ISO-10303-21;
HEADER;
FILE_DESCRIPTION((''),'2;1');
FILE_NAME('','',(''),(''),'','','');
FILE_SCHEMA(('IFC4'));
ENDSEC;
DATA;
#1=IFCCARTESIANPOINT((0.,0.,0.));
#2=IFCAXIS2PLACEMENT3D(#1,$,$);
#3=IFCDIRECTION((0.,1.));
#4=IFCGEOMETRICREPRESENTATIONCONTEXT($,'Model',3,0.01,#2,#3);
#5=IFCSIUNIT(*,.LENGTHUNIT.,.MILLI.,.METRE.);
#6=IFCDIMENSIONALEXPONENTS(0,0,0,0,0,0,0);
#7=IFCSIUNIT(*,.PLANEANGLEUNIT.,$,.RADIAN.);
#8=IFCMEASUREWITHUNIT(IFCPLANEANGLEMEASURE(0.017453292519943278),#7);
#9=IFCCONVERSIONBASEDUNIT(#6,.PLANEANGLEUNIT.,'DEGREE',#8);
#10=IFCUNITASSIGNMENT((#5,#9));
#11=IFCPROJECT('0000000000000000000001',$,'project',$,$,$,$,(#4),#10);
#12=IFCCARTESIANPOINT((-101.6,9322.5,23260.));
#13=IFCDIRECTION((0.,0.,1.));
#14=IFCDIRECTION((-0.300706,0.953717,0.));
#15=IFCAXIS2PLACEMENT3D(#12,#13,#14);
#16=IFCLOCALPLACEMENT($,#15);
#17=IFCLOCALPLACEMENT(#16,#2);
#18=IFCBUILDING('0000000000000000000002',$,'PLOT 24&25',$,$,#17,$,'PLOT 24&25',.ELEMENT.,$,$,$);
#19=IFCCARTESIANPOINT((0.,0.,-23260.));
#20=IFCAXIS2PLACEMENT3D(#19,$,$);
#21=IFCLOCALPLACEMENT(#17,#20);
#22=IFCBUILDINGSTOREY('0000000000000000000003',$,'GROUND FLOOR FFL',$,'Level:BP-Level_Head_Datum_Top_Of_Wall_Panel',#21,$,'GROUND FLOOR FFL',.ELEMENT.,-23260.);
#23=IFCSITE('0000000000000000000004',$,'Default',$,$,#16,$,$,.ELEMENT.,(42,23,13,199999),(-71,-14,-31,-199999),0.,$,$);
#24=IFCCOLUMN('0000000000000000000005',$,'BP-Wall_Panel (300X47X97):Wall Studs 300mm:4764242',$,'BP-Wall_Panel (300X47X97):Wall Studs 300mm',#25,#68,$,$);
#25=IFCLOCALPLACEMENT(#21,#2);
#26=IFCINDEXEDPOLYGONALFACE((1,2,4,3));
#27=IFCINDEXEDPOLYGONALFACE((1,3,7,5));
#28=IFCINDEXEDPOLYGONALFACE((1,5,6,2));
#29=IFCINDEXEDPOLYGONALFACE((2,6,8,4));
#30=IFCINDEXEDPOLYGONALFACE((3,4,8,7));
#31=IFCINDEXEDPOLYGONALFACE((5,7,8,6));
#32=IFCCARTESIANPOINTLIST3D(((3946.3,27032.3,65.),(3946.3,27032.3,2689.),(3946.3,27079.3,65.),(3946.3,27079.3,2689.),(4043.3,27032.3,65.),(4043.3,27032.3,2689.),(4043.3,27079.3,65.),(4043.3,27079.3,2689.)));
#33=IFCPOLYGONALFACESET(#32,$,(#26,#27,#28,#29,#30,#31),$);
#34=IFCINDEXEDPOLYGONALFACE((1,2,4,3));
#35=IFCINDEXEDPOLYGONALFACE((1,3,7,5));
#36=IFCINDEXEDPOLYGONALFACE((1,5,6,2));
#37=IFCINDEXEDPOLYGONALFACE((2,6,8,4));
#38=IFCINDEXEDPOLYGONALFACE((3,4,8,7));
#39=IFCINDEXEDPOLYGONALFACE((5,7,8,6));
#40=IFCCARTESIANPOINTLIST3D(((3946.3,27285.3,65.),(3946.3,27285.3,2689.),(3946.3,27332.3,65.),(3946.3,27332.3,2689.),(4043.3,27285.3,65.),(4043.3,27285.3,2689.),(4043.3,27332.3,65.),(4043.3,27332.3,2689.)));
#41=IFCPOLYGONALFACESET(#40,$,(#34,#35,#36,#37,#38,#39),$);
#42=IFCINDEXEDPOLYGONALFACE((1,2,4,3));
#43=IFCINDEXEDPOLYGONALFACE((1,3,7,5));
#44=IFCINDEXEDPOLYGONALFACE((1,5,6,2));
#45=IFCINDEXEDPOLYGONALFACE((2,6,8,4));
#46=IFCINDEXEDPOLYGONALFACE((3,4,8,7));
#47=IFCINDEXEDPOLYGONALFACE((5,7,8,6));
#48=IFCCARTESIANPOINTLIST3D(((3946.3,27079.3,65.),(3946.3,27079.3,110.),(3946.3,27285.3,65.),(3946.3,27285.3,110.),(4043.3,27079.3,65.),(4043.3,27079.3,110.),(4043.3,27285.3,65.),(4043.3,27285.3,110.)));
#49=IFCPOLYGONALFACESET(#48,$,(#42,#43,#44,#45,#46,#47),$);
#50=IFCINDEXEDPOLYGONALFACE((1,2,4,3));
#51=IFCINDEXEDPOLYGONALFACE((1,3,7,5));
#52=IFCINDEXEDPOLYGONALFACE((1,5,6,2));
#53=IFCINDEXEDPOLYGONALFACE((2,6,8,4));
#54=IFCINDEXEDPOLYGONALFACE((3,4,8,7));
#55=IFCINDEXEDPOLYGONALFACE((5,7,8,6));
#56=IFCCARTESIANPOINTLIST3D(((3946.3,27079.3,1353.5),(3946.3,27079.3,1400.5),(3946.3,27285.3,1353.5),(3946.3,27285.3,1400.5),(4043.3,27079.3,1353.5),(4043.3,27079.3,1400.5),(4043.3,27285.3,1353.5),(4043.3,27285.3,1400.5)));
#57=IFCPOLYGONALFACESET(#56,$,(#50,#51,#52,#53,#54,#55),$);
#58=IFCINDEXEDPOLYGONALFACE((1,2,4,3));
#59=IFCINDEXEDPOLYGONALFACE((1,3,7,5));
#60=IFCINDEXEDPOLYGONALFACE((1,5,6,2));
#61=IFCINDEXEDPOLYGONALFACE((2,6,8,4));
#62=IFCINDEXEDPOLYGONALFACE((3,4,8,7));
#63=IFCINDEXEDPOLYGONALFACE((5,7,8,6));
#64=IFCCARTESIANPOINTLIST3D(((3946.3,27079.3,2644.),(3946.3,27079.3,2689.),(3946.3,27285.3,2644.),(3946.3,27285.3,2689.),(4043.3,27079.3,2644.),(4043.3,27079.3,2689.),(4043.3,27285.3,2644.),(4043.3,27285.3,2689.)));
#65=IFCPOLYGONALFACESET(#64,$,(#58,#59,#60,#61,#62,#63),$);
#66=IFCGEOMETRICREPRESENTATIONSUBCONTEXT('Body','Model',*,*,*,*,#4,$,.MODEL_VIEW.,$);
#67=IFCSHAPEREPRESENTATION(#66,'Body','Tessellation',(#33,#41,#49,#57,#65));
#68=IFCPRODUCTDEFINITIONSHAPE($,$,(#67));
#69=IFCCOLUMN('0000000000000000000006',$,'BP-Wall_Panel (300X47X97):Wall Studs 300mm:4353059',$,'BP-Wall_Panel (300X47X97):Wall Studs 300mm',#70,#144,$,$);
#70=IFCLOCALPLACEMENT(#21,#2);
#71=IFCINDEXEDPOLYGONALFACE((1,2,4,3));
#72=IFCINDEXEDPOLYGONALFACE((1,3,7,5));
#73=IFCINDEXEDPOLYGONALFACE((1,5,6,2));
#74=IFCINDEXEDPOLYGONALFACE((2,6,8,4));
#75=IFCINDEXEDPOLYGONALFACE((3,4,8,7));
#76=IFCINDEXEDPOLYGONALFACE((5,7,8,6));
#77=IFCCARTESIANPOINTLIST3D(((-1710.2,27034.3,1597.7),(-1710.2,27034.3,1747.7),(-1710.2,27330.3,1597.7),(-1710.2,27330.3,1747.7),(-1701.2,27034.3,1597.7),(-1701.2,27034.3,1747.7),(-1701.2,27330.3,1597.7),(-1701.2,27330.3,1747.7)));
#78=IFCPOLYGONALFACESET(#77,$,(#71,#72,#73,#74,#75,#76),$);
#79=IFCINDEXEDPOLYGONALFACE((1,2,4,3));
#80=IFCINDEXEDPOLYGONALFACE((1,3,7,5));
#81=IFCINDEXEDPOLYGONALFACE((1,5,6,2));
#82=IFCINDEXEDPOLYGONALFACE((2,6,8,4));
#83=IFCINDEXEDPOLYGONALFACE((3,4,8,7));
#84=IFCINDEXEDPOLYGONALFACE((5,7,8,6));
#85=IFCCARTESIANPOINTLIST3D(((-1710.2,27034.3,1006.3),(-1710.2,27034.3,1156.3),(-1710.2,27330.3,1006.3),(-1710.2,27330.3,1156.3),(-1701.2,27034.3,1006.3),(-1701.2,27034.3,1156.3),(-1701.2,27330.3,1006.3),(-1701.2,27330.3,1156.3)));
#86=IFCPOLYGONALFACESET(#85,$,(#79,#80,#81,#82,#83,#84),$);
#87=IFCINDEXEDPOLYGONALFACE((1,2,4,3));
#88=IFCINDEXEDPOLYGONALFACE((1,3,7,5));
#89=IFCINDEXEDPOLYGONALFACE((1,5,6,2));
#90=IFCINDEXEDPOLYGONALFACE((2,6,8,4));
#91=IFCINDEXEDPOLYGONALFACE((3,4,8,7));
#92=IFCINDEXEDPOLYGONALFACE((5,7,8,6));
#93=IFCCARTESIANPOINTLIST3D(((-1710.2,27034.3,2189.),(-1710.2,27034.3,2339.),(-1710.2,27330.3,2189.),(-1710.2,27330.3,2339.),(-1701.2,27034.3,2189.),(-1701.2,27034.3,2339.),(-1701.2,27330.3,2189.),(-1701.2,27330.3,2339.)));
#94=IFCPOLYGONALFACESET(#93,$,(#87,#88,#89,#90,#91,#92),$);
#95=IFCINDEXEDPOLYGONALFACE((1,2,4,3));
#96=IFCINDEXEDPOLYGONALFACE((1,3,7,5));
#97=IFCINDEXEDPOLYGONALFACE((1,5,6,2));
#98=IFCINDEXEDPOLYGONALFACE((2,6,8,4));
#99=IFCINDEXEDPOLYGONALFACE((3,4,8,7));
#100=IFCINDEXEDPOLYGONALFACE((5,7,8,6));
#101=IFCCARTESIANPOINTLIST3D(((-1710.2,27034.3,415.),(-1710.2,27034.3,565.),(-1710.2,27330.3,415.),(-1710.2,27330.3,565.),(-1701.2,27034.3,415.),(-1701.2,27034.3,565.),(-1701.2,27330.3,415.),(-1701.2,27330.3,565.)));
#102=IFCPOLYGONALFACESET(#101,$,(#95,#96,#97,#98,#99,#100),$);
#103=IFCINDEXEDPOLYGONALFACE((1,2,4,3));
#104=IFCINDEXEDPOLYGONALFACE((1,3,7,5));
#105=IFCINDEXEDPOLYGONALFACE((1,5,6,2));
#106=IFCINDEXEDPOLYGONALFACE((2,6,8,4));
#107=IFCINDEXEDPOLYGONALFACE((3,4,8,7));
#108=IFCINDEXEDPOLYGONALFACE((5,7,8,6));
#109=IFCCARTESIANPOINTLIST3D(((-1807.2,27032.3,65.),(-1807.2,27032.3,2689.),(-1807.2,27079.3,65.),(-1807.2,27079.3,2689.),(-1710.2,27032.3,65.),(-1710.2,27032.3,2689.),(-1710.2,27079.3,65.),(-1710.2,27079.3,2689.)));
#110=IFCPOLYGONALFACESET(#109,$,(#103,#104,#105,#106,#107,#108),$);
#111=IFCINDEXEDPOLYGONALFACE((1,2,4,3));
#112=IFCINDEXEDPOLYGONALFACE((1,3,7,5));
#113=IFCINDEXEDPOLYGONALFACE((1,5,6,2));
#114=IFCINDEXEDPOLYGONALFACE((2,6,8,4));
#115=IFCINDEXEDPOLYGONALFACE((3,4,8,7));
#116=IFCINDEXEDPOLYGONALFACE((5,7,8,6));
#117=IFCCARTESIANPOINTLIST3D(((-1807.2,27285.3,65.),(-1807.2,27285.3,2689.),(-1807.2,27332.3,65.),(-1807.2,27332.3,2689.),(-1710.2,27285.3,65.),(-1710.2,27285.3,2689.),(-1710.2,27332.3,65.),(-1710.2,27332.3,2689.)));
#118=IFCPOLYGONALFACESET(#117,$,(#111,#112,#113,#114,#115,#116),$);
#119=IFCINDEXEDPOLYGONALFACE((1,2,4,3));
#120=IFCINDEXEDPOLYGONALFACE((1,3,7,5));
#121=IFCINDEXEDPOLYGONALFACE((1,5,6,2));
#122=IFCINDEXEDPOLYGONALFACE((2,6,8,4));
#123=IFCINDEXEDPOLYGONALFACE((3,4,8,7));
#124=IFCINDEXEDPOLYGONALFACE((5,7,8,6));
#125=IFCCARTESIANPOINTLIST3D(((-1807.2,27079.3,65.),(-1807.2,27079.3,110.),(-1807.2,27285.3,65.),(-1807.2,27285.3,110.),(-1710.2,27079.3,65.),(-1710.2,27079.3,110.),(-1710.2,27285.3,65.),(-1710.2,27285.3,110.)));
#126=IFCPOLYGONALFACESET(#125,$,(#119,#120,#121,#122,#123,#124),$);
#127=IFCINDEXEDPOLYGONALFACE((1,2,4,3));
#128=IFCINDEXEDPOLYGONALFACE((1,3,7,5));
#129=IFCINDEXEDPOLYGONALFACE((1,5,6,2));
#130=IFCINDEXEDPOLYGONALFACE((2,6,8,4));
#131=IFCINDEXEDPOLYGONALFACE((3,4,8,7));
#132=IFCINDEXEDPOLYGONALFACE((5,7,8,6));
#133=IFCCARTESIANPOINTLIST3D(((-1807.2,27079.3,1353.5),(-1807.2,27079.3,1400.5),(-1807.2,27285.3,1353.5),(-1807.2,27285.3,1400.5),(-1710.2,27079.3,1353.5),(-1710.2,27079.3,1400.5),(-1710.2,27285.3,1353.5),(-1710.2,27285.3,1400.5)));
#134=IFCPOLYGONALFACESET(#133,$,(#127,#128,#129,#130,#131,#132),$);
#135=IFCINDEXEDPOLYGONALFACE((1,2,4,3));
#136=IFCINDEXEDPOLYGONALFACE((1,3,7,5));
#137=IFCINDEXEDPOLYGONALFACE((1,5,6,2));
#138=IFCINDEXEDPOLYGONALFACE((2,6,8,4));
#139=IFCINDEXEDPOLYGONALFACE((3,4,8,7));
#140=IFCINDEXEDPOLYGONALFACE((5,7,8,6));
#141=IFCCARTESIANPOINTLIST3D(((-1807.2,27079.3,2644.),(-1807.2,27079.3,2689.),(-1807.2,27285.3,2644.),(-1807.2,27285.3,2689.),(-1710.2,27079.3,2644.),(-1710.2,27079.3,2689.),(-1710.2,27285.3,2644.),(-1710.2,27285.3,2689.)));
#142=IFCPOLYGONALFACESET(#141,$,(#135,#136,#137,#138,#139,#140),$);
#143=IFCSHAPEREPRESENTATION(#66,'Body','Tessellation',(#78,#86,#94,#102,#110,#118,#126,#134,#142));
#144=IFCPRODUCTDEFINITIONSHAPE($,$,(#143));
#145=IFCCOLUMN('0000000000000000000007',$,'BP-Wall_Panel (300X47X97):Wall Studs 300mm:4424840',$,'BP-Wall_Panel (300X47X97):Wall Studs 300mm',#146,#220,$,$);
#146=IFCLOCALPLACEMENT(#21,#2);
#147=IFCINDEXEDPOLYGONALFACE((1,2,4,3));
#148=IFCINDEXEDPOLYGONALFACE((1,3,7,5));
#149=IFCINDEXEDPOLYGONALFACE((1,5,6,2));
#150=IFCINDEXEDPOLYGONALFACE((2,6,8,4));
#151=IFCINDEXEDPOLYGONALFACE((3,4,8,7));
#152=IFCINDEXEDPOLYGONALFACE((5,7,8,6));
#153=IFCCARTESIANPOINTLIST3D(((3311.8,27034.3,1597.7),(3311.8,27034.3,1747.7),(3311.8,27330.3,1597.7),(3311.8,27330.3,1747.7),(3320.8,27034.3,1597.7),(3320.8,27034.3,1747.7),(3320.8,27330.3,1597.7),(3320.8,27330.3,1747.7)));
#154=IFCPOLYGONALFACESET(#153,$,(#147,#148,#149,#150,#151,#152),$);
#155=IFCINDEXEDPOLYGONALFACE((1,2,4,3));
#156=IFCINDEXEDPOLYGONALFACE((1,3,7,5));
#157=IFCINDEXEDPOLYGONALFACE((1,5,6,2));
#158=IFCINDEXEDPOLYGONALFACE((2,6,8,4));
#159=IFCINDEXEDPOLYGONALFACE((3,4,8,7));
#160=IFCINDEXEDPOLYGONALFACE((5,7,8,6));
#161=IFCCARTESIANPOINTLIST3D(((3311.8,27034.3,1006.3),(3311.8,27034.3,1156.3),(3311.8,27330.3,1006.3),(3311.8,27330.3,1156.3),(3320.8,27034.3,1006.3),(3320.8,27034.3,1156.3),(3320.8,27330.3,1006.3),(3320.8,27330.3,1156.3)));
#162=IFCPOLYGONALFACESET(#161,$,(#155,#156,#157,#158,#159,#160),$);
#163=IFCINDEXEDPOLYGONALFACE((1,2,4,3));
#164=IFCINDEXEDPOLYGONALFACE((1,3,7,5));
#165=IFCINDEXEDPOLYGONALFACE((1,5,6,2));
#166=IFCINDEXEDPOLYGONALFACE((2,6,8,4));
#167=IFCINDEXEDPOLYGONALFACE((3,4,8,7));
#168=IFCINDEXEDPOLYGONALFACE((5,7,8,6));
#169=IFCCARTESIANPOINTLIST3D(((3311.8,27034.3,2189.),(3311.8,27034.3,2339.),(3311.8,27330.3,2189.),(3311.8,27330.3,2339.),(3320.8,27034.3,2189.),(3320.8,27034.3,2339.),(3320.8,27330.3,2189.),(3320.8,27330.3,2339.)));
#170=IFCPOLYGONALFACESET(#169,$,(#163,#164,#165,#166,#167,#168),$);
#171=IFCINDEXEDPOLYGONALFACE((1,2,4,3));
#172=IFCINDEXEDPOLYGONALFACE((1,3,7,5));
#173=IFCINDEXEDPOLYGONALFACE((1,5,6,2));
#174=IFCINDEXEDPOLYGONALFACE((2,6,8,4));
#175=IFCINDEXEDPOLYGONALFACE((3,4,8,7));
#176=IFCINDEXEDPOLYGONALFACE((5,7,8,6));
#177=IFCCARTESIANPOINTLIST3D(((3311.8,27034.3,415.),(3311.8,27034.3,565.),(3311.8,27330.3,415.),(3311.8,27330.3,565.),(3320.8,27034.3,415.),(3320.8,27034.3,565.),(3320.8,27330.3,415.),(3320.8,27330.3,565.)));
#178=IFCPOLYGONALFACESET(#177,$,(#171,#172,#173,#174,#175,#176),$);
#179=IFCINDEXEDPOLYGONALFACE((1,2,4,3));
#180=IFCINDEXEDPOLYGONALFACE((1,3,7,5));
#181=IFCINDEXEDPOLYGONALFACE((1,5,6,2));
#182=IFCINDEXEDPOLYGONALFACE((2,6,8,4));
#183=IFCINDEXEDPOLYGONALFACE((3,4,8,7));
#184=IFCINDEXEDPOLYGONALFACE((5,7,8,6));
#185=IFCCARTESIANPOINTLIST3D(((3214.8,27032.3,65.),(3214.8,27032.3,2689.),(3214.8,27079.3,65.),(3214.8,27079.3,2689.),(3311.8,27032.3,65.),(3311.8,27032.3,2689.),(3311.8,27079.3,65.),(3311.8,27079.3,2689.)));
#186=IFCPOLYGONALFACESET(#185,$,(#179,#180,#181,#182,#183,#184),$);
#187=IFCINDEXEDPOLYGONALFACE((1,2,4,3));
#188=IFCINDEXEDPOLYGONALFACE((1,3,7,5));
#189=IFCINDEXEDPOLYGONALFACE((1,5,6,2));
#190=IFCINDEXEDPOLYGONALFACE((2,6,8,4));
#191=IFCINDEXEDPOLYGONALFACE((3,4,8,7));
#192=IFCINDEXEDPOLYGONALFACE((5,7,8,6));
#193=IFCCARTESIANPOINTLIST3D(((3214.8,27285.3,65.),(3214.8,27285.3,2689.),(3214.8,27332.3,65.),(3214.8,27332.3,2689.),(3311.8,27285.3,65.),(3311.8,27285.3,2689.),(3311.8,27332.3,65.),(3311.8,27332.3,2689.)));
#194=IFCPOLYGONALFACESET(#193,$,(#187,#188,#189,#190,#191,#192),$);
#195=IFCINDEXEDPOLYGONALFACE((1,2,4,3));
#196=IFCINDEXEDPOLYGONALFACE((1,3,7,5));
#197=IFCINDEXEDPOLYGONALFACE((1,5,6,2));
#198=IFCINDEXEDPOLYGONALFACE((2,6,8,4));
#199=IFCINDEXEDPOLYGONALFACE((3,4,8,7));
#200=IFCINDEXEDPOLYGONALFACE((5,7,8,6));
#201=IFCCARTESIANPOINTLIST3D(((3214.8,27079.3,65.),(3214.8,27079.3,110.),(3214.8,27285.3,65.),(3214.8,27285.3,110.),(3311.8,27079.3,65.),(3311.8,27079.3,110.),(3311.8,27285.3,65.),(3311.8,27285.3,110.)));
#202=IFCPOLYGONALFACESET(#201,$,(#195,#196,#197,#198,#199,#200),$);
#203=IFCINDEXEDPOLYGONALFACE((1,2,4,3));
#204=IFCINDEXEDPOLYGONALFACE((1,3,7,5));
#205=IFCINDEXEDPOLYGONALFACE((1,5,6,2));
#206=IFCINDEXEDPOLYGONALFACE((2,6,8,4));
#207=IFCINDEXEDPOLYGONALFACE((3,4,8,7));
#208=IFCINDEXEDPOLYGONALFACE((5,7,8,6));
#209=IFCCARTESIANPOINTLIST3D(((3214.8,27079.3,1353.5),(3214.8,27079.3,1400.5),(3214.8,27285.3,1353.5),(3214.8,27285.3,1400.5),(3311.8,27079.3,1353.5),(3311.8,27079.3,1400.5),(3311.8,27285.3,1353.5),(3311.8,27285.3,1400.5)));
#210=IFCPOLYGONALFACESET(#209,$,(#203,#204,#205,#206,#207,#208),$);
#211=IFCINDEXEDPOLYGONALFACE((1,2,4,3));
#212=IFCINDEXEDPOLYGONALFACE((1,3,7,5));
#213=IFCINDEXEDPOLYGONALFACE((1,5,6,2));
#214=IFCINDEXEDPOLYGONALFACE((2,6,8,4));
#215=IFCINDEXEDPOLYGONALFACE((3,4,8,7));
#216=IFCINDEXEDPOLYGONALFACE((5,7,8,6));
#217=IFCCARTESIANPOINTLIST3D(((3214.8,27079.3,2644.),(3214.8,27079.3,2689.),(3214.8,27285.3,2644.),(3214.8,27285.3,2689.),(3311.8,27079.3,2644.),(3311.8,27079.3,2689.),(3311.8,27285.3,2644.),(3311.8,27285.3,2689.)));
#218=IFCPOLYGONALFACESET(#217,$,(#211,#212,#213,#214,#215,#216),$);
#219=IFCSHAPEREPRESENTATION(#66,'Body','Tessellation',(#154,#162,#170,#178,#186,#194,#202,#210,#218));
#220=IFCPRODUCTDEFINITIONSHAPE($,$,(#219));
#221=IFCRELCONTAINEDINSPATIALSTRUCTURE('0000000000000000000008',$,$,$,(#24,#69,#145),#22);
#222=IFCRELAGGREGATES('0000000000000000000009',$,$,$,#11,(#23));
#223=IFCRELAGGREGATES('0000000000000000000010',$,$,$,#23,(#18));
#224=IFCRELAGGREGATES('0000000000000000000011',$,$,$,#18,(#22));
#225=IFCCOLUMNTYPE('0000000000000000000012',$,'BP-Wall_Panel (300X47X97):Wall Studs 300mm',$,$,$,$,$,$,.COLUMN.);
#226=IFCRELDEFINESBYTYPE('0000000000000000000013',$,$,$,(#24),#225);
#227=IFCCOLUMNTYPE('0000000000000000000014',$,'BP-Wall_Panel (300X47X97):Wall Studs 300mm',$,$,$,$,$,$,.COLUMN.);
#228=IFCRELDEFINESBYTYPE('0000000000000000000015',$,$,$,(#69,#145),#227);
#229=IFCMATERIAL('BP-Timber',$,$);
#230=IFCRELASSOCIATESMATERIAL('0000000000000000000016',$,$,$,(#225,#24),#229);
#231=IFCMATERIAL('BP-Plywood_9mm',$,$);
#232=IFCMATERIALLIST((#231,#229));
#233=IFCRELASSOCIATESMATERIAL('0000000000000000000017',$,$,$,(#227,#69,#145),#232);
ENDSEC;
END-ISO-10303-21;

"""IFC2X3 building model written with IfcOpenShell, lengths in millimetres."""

from ifc_helpers import new_model, entity, si_unit, converted_unit, direction, frame, frame_2d, origin, origin_2d_with_axis, place, context, subcontext, project, spatial, rectangle, extrude, source, transform, mapped, material, material_list, type_object, type_shapes, element, save


model = new_model("IFC2X3")

# Units and contexts
model_context = context("Model", 3, precision=0.01, world=origin(), true_north=direction((0.0, 1.0)))
body_context = subcontext(model_context, "Body", "Model", "MODEL_VIEW")
ifc_project = project(units=[si_unit("LENGTHUNIT", "METRE", prefix="MILLI"), converted_unit("PLANEANGLEUNIT", "DEGREE", entity("IfcPlaneAngleMeasure", 0.017453292519943278), si_unit("PLANEANGLEUNIT", "RADIAN"), dimensions=[0, 0, 0, 0, 0, 0, 0])], contexts=[model_context])

# Site, building, storey
site_placement = place(None, frame((-101.6, 9322.5, 23260.0), z_axis=(0.0, 0.0, 1.0), x_axis=(-0.300706, 0.953717, 0.0)))
site = spatial("IfcSite", under=ifc_project, at=site_placement, Name="Default", CompositionType="ELEMENT", RefLatitude=(42, 23, 13, 199999), RefLongitude=(-71, -14, -31, -199999), RefElevation=0.0)
building_placement = place(site_placement, origin())
building = spatial("IfcBuilding", under=site, at=building_placement, Name="PLOT 24&25", LongName="PLOT 24&25", CompositionType="ELEMENT")
storey_placement = place(building_placement, frame((0.0, 0.0, -23260.0)))
storey = spatial("IfcBuildingStorey", under=building, at=storey_placement, Name="GROUND FLOOR FFL", ObjectType="Level:BP-Level_Head_Datum_Top_Of_Wall_Panel", LongName="GROUND FLOOR FFL", CompositionType="ELEMENT", Elevation=-23260.0)

# Columns
ifc_material_1 = material(Name="BP-Plywood_9mm")
ifc_material_2 = material(Name="BP-Timber")
ifc_material_list = material_list([ifc_material_1, ifc_material_2])
column_type_1 = type_object("IfcColumnType", Name="BP-Wall_Panel (300X47X97):Wall Studs 300mm", PredefinedType="COLUMN", material=ifc_material_2)
shared_shape_1 = source(origin(), body_context, "Body", "SweptSolid", [
    extrude(rectangle(XDim=97.0, YDim=47.0, at=origin_2d_with_axis()), frame((0.0, -126.5, -23195.0), z_axis=(0.0, 0.0, 1.0), x_axis=(-1.0, 0.0, 0.0)), (0.0, 0.0, 1.0), 2624.0),
    extrude(rectangle(XDim=97.0, YDim=47.0, at=frame_2d((0.0, 0.0), x_axis=(1.0, 0.0))), frame((0.0, 126.5, -23195.0), z_axis=(0.0, 0.0, 1.0), x_axis=(-1.0, 0.0, 0.0)), (0.0, 0.0, 1.0), 2624.0),
    extrude(rectangle(XDim=206.0, YDim=97.0, at=origin_2d_with_axis()), frame((0.0, 0.0, -23195.0), z_axis=(0.0, 0.0, 1.0), x_axis=(0.0, -1.0, 0.0)), (0.0, 0.0, 1.0), 45.0),
    extrude(rectangle(XDim=206.0, YDim=97.0, at=origin_2d_with_axis()), frame((0.0, 0.0, -21906.5), z_axis=(0.0, 0.0, 1.0), x_axis=(0.0, -1.0, 0.0)), (0.0, 0.0, 1.0), 47.0),
    extrude(rectangle(XDim=206.0, YDim=97.0, at=origin_2d_with_axis()), frame((0.0, 0.0, -20616.0), z_axis=(0.0, 0.0, 1.0), x_axis=(0.0, -1.0, 0.0)), (0.0, 0.0, 1.0), 45.0),
])
type_shapes(column_type_1, [shared_shape_1])
for number, where, name in (
    (1, (3994.8, 27182.3, 23260.0), "BP-Wall_Panel (300X47X97):Wall Studs 300mm:4764242"),
):
    element("IfcColumn", number, at=place(storey_placement, frame(where)), inside=storey, type_object=column_type_1, material=ifc_material_2, Name=name, ObjectType="BP-Wall_Panel (300X47X97):Wall Studs 300mm", context=body_context, shape_type="MappedRepresentation", body=[
        mapped(shared_shape_1, transform((0.0, 0.0, 0.0), scale=1.0)),
    ])
column_type_2 = type_object("IfcColumnType", Name="BP-Wall_Panel (300X47X97):Wall Studs 300mm", PredefinedType="COLUMN", material=ifc_material_list)
shared_shape_2 = source(origin(), body_context, "Body", "SweptSolid", [
    extrude(rectangle(XDim=296.0, YDim=9.0, at=origin_2d_with_axis()), frame((53.0, 0.0, -21662.3), z_axis=(0.0, 0.0, 1.0), x_axis=(0.0, -1.0, 0.0)), (0.0, 0.0, 1.0), 150.0),
    extrude(rectangle(XDim=296.0, YDim=9.0, at=origin_2d_with_axis()), frame((53.0, 0.0, -22253.7), z_axis=(0.0, 0.0, 1.0), x_axis=(0.0, -1.0, 0.0)), (0.0, 0.0, 1.0), 150.0),
    extrude(rectangle(XDim=296.0, YDim=9.0, at=origin_2d_with_axis()), frame((53.0, 0.0, -21071.0), z_axis=(0.0, 0.0, 1.0), x_axis=(0.0, -1.0, 0.0)), (0.0, 0.0, 1.0), 150.0),
    extrude(rectangle(XDim=296.0, YDim=9.0, at=origin_2d_with_axis()), frame((53.0, 0.0, -22845.0), z_axis=(0.0, 0.0, 1.0), x_axis=(0.0, -1.0, 0.0)), (0.0, 0.0, 1.0), 150.0),
    extrude(rectangle(XDim=97.0, YDim=47.0, at=origin_2d_with_axis()), frame((0.0, -126.5, -23195.0), z_axis=(0.0, 0.0, 1.0), x_axis=(-1.0, 0.0, 0.0)), (0.0, 0.0, 1.0), 2624.0),
    extrude(rectangle(XDim=97.0, YDim=47.0, at=frame_2d((0.0, 0.0), x_axis=(1.0, 0.0))), frame((0.0, 126.5, -23195.0), z_axis=(0.0, 0.0, 1.0), x_axis=(-1.0, 0.0, 0.0)), (0.0, 0.0, 1.0), 2624.0),
    extrude(rectangle(XDim=206.0, YDim=97.0, at=origin_2d_with_axis()), frame((0.0, 0.0, -23195.0), z_axis=(0.0, 0.0, 1.0), x_axis=(0.0, -1.0, 0.0)), (0.0, 0.0, 1.0), 45.0),
    extrude(rectangle(XDim=206.0, YDim=97.0, at=origin_2d_with_axis()), frame((0.0, 0.0, -21906.5), z_axis=(0.0, 0.0, 1.0), x_axis=(0.0, -1.0, 0.0)), (0.0, 0.0, 1.0), 47.0),
    extrude(rectangle(XDim=206.0, YDim=97.0, at=origin_2d_with_axis()), frame((0.0, 0.0, -20616.0), z_axis=(0.0, 0.0, 1.0), x_axis=(0.0, -1.0, 0.0)), (0.0, 0.0, 1.0), 45.0),
])
type_shapes(column_type_2, [shared_shape_2])
for number, where, name in (
    (2, (-1758.7, 27182.3, 23260.0), "BP-Wall_Panel (300X47X97):Wall Studs 300mm:4353059"),
    (3, (3263.3, 27182.3, 23260.0), "BP-Wall_Panel (300X47X97):Wall Studs 300mm:4424840"),
):
    element("IfcColumn", number, at=place(storey_placement, frame(where)), inside=storey, type_object=column_type_2, material=ifc_material_list, Name=name, ObjectType="BP-Wall_Panel (300X47X97):Wall Studs 300mm", context=body_context, shape_type="MappedRepresentation", body=[
        mapped(shared_shape_2, transform((0.0, 0.0, 0.0), scale=1.0)),
    ])

save(model, "model.ifc")
